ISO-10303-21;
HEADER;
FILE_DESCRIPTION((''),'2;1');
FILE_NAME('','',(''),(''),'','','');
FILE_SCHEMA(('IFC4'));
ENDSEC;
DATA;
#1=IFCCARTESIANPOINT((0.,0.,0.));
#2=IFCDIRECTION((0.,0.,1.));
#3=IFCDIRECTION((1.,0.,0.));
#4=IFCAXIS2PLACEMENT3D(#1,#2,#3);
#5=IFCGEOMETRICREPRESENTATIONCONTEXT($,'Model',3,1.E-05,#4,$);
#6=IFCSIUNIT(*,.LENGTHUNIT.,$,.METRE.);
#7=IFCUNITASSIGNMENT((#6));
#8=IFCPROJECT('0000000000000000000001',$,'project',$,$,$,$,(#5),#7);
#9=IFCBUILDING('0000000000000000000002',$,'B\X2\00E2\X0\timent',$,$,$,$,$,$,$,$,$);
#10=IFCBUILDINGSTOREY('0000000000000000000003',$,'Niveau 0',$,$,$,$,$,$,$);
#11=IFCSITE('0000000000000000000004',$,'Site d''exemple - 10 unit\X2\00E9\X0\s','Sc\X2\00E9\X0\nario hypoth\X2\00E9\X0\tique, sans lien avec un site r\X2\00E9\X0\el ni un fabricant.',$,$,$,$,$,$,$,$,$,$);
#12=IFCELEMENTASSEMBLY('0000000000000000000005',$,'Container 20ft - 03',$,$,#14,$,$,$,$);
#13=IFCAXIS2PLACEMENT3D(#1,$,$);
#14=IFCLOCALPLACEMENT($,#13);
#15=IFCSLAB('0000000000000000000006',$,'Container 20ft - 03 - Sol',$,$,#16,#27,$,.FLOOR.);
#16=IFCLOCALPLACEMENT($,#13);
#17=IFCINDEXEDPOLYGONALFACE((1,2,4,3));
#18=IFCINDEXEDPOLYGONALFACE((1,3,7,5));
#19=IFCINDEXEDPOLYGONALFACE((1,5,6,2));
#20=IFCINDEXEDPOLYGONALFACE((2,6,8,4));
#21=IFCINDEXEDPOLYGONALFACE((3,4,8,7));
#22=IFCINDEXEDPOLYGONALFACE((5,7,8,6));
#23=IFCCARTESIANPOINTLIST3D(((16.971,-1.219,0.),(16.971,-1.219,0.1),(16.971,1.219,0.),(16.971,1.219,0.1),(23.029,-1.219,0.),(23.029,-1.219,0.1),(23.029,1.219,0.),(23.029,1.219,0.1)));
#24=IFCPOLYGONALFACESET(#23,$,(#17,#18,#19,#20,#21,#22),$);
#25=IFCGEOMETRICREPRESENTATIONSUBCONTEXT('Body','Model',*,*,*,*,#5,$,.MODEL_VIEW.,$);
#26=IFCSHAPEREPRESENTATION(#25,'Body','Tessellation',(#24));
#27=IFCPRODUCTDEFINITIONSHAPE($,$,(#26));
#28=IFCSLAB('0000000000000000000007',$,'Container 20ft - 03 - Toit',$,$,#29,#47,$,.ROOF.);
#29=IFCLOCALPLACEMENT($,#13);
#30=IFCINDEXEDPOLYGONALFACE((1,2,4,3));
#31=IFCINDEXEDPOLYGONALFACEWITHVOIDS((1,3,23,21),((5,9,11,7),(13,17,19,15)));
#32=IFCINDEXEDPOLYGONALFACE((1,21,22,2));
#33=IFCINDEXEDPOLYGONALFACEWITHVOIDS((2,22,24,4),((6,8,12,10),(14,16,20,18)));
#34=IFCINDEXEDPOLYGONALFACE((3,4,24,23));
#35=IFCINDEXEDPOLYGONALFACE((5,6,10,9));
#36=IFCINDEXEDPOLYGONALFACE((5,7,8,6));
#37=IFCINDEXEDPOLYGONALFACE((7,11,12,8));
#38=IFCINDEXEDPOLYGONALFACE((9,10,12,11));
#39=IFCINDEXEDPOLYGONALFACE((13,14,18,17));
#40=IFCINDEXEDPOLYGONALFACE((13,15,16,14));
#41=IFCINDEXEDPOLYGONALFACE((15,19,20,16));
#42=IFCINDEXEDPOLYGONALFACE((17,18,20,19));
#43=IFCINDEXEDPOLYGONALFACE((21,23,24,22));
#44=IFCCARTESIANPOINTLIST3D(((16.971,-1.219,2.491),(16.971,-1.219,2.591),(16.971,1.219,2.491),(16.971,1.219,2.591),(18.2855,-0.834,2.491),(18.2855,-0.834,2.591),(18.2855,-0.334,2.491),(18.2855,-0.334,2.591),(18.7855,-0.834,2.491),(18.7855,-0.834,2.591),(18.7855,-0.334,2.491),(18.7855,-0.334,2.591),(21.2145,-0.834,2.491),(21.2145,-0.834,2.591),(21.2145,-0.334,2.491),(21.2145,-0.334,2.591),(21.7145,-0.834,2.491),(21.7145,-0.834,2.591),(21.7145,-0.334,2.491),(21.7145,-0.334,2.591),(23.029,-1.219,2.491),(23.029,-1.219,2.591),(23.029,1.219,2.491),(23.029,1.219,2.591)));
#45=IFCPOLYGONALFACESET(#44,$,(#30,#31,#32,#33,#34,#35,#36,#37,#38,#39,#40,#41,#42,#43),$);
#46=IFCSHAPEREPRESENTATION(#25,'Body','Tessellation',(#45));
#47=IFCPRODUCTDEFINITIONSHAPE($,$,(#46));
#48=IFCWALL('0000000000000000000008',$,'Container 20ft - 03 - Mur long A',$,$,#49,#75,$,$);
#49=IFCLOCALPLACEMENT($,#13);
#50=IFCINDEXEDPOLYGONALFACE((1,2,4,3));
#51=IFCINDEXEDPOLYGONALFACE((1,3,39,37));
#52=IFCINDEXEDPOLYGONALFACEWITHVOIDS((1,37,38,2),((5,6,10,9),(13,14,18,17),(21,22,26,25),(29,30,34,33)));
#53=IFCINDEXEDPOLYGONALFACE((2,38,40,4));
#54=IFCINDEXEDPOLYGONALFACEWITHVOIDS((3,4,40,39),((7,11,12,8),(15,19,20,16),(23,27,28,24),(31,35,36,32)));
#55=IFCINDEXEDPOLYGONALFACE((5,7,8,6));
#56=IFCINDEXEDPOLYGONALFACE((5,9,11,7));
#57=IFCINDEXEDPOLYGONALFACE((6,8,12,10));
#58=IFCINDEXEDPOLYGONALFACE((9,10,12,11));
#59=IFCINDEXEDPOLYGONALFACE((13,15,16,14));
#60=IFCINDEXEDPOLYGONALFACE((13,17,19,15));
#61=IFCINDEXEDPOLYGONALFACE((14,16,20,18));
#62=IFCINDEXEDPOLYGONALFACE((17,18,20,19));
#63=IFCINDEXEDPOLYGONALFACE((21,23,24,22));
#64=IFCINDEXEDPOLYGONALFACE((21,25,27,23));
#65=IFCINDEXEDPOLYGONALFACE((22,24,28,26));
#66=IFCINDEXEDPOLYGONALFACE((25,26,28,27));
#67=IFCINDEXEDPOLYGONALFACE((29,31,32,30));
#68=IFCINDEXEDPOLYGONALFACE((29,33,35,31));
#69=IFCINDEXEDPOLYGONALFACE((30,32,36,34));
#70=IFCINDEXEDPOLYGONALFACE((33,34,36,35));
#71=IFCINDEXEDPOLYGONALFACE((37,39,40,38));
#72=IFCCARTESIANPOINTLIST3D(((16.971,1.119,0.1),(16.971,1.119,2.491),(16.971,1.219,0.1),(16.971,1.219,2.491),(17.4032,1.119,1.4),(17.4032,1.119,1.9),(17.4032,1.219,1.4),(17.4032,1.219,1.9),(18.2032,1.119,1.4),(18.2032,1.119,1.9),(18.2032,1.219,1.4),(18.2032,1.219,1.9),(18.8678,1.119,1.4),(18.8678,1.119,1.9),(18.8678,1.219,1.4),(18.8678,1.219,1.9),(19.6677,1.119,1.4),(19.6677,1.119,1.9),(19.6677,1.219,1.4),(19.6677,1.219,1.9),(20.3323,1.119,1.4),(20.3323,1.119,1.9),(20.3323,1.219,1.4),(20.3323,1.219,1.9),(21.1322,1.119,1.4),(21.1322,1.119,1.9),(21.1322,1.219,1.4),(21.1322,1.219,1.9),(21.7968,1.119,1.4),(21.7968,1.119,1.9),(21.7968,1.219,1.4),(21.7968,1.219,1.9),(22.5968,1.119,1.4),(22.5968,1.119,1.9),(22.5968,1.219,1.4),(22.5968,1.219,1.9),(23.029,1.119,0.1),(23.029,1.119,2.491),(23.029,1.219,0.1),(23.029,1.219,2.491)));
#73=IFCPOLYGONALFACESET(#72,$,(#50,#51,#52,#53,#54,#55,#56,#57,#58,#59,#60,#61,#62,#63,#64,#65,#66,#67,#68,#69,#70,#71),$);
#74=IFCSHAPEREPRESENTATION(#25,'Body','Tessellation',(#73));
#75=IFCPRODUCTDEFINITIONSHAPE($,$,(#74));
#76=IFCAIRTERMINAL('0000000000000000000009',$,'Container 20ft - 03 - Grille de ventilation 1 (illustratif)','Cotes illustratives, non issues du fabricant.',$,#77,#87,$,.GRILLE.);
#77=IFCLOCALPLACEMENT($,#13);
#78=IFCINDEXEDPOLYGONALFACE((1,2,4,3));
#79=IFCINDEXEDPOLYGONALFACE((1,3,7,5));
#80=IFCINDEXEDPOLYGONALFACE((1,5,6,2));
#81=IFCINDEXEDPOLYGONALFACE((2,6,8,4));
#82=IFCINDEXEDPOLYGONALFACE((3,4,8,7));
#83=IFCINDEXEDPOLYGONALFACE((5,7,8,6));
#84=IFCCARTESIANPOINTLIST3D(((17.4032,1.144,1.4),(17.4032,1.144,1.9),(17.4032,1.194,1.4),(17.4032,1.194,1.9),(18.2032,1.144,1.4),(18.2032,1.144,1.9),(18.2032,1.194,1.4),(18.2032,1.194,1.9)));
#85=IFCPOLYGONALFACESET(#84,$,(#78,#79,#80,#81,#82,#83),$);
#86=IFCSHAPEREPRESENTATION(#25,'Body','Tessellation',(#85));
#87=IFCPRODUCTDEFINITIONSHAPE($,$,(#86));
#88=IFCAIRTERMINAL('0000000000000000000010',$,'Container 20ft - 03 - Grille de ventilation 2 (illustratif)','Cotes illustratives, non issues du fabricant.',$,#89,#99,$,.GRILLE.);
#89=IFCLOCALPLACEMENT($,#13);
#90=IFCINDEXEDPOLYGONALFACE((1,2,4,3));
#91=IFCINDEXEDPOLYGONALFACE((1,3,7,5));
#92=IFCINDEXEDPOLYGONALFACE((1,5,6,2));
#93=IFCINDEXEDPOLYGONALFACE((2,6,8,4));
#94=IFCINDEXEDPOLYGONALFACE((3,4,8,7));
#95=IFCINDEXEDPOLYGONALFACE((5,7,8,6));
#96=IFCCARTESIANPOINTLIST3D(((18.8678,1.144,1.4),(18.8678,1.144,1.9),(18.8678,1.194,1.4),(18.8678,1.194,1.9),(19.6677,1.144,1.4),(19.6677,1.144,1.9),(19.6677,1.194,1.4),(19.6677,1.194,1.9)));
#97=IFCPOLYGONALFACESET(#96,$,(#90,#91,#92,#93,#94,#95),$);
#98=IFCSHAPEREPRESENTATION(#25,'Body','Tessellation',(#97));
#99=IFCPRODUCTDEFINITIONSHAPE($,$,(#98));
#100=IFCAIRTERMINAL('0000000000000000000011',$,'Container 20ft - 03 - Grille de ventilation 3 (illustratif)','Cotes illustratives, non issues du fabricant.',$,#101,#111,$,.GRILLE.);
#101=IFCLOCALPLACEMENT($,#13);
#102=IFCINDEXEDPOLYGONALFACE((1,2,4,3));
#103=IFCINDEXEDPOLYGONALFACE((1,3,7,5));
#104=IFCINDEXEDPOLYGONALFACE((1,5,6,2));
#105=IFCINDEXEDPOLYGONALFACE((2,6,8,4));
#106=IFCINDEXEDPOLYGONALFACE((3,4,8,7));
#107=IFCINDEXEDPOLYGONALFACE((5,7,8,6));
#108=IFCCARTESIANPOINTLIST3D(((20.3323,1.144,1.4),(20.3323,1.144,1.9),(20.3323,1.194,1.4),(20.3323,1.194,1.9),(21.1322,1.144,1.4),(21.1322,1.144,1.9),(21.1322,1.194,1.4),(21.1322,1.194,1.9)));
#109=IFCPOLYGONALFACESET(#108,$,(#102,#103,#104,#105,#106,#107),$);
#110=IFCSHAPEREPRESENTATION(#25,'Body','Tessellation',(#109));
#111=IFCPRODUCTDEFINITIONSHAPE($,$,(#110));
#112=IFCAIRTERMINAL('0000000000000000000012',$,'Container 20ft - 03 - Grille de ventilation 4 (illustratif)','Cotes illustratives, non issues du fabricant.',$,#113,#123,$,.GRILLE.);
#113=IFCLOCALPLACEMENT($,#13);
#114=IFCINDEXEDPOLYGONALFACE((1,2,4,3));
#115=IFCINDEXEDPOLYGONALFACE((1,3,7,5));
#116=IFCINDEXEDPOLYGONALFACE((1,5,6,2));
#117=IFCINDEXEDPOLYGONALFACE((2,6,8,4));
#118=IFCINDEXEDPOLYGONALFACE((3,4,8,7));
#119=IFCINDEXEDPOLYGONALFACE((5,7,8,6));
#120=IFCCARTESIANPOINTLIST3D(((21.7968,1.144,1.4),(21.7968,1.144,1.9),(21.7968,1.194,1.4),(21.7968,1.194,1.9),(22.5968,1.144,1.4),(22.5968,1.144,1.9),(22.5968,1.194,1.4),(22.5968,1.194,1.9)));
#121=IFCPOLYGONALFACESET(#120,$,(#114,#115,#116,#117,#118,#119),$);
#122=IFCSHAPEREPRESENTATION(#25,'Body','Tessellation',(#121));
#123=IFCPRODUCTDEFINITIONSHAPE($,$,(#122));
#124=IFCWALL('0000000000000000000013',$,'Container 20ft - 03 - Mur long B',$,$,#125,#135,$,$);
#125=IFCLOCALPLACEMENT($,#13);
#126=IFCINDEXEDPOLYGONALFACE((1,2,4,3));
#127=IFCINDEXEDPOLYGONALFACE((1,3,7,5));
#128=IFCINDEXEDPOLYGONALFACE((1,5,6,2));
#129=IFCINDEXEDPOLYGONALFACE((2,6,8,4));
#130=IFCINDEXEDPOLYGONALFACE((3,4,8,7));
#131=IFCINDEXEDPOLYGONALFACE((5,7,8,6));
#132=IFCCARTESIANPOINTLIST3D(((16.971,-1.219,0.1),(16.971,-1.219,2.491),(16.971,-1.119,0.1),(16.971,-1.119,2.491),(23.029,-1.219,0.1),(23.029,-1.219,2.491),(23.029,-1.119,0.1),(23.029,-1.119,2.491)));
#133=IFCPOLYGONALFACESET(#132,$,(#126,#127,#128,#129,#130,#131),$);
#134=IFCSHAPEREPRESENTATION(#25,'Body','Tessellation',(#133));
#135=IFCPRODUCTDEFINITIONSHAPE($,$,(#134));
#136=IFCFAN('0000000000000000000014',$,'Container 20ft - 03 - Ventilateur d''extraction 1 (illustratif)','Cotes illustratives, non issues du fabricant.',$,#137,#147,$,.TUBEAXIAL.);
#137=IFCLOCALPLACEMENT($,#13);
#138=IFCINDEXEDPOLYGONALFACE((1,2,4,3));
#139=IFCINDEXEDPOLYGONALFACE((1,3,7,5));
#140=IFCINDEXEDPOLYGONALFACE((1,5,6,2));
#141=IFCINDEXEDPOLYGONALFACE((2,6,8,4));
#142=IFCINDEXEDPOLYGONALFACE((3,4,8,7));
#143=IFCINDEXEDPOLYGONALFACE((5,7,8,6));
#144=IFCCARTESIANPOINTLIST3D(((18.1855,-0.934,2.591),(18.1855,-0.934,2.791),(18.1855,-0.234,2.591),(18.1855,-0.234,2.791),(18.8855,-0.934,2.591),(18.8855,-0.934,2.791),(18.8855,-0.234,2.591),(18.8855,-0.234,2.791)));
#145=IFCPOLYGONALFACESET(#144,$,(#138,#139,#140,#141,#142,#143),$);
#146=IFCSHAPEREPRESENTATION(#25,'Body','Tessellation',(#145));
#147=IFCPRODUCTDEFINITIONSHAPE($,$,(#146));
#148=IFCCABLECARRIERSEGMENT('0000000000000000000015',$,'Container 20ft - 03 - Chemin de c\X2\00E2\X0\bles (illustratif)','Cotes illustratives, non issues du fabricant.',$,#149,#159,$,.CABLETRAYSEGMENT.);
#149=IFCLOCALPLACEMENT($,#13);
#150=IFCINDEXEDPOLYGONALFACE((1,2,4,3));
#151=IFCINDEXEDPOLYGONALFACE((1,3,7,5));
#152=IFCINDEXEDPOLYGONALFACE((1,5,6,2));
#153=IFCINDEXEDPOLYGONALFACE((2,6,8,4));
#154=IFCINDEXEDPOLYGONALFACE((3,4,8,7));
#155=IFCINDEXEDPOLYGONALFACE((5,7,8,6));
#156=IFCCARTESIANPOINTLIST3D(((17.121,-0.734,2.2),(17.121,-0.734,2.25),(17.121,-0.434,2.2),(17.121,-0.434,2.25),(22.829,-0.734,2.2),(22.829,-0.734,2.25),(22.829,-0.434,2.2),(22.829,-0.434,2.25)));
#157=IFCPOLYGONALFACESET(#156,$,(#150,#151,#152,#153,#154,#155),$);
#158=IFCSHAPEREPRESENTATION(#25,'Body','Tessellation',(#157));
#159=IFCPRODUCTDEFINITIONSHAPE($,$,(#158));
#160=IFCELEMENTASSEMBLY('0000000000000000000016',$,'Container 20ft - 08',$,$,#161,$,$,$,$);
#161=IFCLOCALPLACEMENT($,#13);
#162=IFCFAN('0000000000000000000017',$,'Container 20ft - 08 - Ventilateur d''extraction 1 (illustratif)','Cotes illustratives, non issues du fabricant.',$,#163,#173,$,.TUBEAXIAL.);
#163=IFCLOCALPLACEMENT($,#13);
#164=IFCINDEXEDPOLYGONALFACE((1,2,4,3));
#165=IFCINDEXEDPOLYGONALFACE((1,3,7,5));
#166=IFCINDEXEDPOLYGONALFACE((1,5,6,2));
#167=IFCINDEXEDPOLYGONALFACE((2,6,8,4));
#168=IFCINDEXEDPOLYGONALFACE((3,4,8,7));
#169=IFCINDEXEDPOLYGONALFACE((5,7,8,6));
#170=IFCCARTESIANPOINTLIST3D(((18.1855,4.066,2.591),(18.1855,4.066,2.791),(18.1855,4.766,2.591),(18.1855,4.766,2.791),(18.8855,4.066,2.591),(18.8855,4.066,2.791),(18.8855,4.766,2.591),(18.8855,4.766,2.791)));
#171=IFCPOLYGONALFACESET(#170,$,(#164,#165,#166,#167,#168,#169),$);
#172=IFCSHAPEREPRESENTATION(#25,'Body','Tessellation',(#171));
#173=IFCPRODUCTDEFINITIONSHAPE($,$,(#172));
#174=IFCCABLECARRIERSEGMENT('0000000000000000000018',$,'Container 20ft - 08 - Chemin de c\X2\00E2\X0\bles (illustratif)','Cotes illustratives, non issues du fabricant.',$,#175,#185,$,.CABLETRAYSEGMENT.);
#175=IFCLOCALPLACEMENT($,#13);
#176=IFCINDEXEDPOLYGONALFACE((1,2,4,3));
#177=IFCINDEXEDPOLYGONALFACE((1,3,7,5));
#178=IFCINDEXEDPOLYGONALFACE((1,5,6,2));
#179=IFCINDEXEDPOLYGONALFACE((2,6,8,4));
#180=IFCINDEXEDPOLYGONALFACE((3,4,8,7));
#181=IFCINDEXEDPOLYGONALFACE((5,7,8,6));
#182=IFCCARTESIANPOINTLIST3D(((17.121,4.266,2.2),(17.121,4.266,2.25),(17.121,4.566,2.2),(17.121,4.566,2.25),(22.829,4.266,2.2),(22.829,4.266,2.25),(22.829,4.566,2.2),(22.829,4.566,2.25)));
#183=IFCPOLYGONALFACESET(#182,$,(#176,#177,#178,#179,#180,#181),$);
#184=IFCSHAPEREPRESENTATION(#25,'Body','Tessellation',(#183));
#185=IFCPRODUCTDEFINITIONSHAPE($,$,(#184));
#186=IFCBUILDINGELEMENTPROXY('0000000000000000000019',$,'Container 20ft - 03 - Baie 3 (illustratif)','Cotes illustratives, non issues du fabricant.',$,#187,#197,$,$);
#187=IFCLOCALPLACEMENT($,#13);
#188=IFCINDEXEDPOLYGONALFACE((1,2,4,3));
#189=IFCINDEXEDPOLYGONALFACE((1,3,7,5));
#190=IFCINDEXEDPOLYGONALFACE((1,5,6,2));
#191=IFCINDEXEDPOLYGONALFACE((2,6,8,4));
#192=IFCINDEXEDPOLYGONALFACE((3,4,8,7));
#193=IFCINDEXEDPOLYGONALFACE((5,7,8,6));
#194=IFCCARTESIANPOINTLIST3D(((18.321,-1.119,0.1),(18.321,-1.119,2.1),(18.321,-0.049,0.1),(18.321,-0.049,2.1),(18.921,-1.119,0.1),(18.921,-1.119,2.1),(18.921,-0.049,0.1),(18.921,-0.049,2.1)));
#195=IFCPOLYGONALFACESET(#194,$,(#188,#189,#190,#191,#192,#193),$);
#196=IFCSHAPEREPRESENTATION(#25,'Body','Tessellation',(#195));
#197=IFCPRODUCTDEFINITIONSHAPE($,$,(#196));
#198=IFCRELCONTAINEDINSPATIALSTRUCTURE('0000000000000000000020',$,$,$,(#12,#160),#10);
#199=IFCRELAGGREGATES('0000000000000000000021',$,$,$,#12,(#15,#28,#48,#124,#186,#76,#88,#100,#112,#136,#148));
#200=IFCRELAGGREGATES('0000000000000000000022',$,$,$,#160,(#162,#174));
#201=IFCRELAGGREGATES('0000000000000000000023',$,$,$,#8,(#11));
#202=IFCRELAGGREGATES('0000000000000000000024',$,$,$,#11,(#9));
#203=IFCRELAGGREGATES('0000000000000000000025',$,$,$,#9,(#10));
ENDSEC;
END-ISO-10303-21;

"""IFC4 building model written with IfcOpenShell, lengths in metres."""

from ifc_helpers import new_model, si_unit, frame, origin_with_axes, place, context, subcontext, project, spatial, rectangle, extrude, element, fill, aggregate, save


model = new_model("IFC4")

# Units and contexts
model_context = context("Model", 3, precision=1e-05, world=origin_with_axes())
body_context = subcontext(model_context, "Body", "Model", "MODEL_VIEW")
ifc_project = project(units=[si_unit("LENGTHUNIT", "METRE")], contexts=[model_context])

# Site, building, storey
site = spatial("IfcSite", under=ifc_project, Name="Site d'exemple - 10 unités", Description="Scénario hypothétique, sans lien avec un site réel ni un fabricant.")
building = spatial("IfcBuilding", under=site, Name="Bâtiment")
storey = spatial("IfcBuildingStorey", under=building, Name="Niveau 0")

# Element assembly, slabs, openings, walls, air terminals, fan, cable carrier segment
assembly_1 = element("IfcElementAssembly", 1, inside=storey, Name="Container 20ft - 03")
slab_1_placement = place(None, frame((20.0, 0.0, 0.0), z_axis=(0.0, 0.0, 1.0), x_axis=(1.0, 0.0, 0.0)))
slab_1 = element("IfcSlab", 2, at=slab_1_placement, Name="Container 20ft - 03 - Sol", PredefinedType="FLOOR", context=body_context, shape_type="SweptSolid", body=[
    extrude(rectangle(XDim=6.058, YDim=2.438), origin_with_axes(), (0.0, 0.0, 1.0), 0.1),
])
slab_2_placement = place(None, frame((20.0, 0.0, 2.491), z_axis=(0.0, 0.0, 1.0), x_axis=(1.0, 0.0, 0.0)))
slab_2 = element("IfcSlab", 3, at=slab_2_placement, Name="Container 20ft - 03 - Toit", PredefinedType="ROOF", context=body_context, shape_type="SweptSolid", body=[
    extrude(rectangle(XDim=6.058, YDim=2.438), origin_with_axes(), (0.0, 0.0, 1.0), 0.1),
])
opening_1_placement = place(None, frame((18.5355, -0.584, 2.441), z_axis=(0.0, 0.0, 1.0), x_axis=(1.0, 0.0, 0.0)))
element("IfcOpeningElement", 4, at=opening_1_placement, cuts=slab_2, PredefinedType="OPENING", context=body_context, shape_type="SweptSolid", body=[
    extrude(rectangle(XDim=0.5, YDim=0.5), origin_with_axes(), (0.0, 0.0, 1.0), 0.2),
])
opening_2_placement = place(None, frame((21.4645, -0.584, 2.441), z_axis=(0.0, 0.0, 1.0), x_axis=(1.0, 0.0, 0.0)))
element("IfcOpeningElement", 5, at=opening_2_placement, cuts=slab_2, PredefinedType="OPENING", context=body_context, shape_type="SweptSolid", body=[
    extrude(rectangle(XDim=0.5, YDim=0.5), origin_with_axes(), (0.0, 0.0, 1.0), 0.2),
])
wall_1_placement = place(None, frame((20.0, 1.169, 0.1), z_axis=(0.0, 0.0, 1.0), x_axis=(1.0, 0.0, 0.0)))
wall_1 = element("IfcWall", 6, at=wall_1_placement, Name="Container 20ft - 03 - Mur long A", context=body_context, shape_type="SweptSolid", body=[
    extrude(rectangle(XDim=6.058, YDim=0.1), origin_with_axes(), (0.0, 0.0, 1.0), 2.391),
])
opening_3_placement = place(None, frame((17.8032, 1.169, 1.4), z_axis=(0.0, 0.0, 1.0), x_axis=(1.0, 0.0, 0.0)))
opening_3 = element("IfcOpeningElement", 7, at=opening_3_placement, cuts=wall_1, PredefinedType="OPENING", context=body_context, shape_type="SweptSolid", body=[
    extrude(rectangle(XDim=0.8, YDim=0.2), origin_with_axes(), (0.0, 0.0, 1.0), 0.5),
])
opening_4_placement = place(None, frame((19.2677, 1.169, 1.4), z_axis=(0.0, 0.0, 1.0), x_axis=(1.0, 0.0, 0.0)))
opening_4 = element("IfcOpeningElement", 8, at=opening_4_placement, cuts=wall_1, PredefinedType="OPENING", context=body_context, shape_type="SweptSolid", body=[
    extrude(rectangle(XDim=0.8, YDim=0.2), origin_with_axes(), (0.0, 0.0, 1.0), 0.5),
])
opening_5_placement = place(None, frame((20.7323, 1.169, 1.4), z_axis=(0.0, 0.0, 1.0), x_axis=(1.0, 0.0, 0.0)))
opening_5 = element("IfcOpeningElement", 9, at=opening_5_placement, cuts=wall_1, PredefinedType="OPENING", context=body_context, shape_type="SweptSolid", body=[
    extrude(rectangle(XDim=0.8, YDim=0.2), origin_with_axes(), (0.0, 0.0, 1.0), 0.5),
])
opening_6_placement = place(None, frame((22.1968, 1.169, 1.4), z_axis=(0.0, 0.0, 1.0), x_axis=(1.0, 0.0, 0.0)))
opening_6 = element("IfcOpeningElement", 10, at=opening_6_placement, cuts=wall_1, PredefinedType="OPENING", context=body_context, shape_type="SweptSolid", body=[
    extrude(rectangle(XDim=0.8, YDim=0.2), origin_with_axes(), (0.0, 0.0, 1.0), 0.5),
])
air_terminal_1_placement = place(None, frame((17.8032, 1.169, 1.4), z_axis=(0.0, 0.0, 1.0), x_axis=(1.0, 0.0, 0.0)))
air_terminal_1 = element("IfcAirTerminal", 11, at=air_terminal_1_placement, Name="Container 20ft - 03 - Grille de ventilation 1 (illustratif)", Description="Cotes illustratives, non issues du fabricant.", PredefinedType="GRILLE", context=body_context, shape_type="SweptSolid", body=[
    extrude(rectangle(XDim=0.8, YDim=0.05), origin_with_axes(), (0.0, 0.0, 1.0), 0.5),
])
fill(opening_3, air_terminal_1)
air_terminal_2_placement = place(None, frame((19.2677, 1.169, 1.4), z_axis=(0.0, 0.0, 1.0), x_axis=(1.0, 0.0, 0.0)))
air_terminal_2 = element("IfcAirTerminal", 12, at=air_terminal_2_placement, Name="Container 20ft - 03 - Grille de ventilation 2 (illustratif)", Description="Cotes illustratives, non issues du fabricant.", PredefinedType="GRILLE", context=body_context, shape_type="SweptSolid", body=[
    extrude(rectangle(XDim=0.8, YDim=0.05), origin_with_axes(), (0.0, 0.0, 1.0), 0.5),
])
fill(opening_4, air_terminal_2)
air_terminal_3_placement = place(None, frame((20.7323, 1.169, 1.4), z_axis=(0.0, 0.0, 1.0), x_axis=(1.0, 0.0, 0.0)))
air_terminal_3 = element("IfcAirTerminal", 13, at=air_terminal_3_placement, Name="Container 20ft - 03 - Grille de ventilation 3 (illustratif)", Description="Cotes illustratives, non issues du fabricant.", PredefinedType="GRILLE", context=body_context, shape_type="SweptSolid", body=[
    extrude(rectangle(XDim=0.8, YDim=0.05), origin_with_axes(), (0.0, 0.0, 1.0), 0.5),
])
fill(opening_5, air_terminal_3)
air_terminal_4_placement = place(None, frame((22.1968, 1.169, 1.4), z_axis=(0.0, 0.0, 1.0), x_axis=(1.0, 0.0, 0.0)))
air_terminal_4 = element("IfcAirTerminal", 14, at=air_terminal_4_placement, Name="Container 20ft - 03 - Grille de ventilation 4 (illustratif)", Description="Cotes illustratives, non issues du fabricant.", PredefinedType="GRILLE", context=body_context, shape_type="SweptSolid", body=[
    extrude(rectangle(XDim=0.8, YDim=0.05), origin_with_axes(), (0.0, 0.0, 1.0), 0.5),
])
fill(opening_6, air_terminal_4)
wall_2_placement = place(None, frame((20.0, -1.169, 0.1), z_axis=(0.0, 0.0, 1.0), x_axis=(1.0, 0.0, 0.0)))
wall_2 = element("IfcWall", 15, at=wall_2_placement, Name="Container 20ft - 03 - Mur long B", context=body_context, shape_type="SweptSolid", body=[
    extrude(rectangle(XDim=6.058, YDim=0.1), origin_with_axes(), (0.0, 0.0, 1.0), 2.391),
])
fan_1_placement = place(None, frame((18.5355, -0.584, 2.591), z_axis=(0.0, 0.0, 1.0), x_axis=(1.0, 0.0, 0.0)))
fan_1 = element("IfcFan", 16, at=fan_1_placement, Name="Container 20ft - 03 - Ventilateur d'extraction 1 (illustratif)", Description="Cotes illustratives, non issues du fabricant.", PredefinedType="TUBEAXIAL", context=body_context, shape_type="SweptSolid", body=[
    extrude(rectangle(XDim=0.7, YDim=0.7), origin_with_axes(), (0.0, 0.0, 1.0), 0.2),
])
cable_carrier_segment_1_placement = place(None, frame((19.975, -0.584, 2.2), z_axis=(0.0, 0.0, 1.0), x_axis=(1.0, 0.0, 0.0)))
cable_carrier_segment_1 = element("IfcCableCarrierSegment", 17, at=cable_carrier_segment_1_placement, Name="Container 20ft - 03 - Chemin de câbles (illustratif)", Description="Cotes illustratives, non issues du fabricant.", PredefinedType="CABLETRAYSEGMENT", context=body_context, shape_type="SweptSolid", body=[
    extrude(rectangle(XDim=5.708, YDim=0.3), origin_with_axes(), (0.0, 0.0, 1.0), 0.05),
])

# Element assembly, fan, cable carrier segment
assembly_2 = element("IfcElementAssembly", 18, inside=storey, Name="Container 20ft - 08")
fan_2_placement = place(None, frame((18.5355, 4.416, 2.591), z_axis=(0.0, 0.0, 1.0), x_axis=(1.0, 0.0, 0.0)))
fan_2 = element("IfcFan", 19, at=fan_2_placement, Name="Container 20ft - 08 - Ventilateur d'extraction 1 (illustratif)", Description="Cotes illustratives, non issues du fabricant.", PredefinedType="TUBEAXIAL", context=body_context, shape_type="SweptSolid", body=[
    extrude(rectangle(XDim=0.7, YDim=0.7), origin_with_axes(), (0.0, 0.0, 1.0), 0.2),
])
cable_carrier_segment_2_placement = place(None, frame((19.975, 4.416, 2.2), z_axis=(0.0, 0.0, 1.0), x_axis=(1.0, 0.0, 0.0)))
cable_carrier_segment_2 = element("IfcCableCarrierSegment", 20, at=cable_carrier_segment_2_placement, Name="Container 20ft - 08 - Chemin de câbles (illustratif)", Description="Cotes illustratives, non issues du fabricant.", PredefinedType="CABLETRAYSEGMENT", context=body_context, shape_type="SweptSolid", body=[
    extrude(rectangle(XDim=5.708, YDim=0.3), origin_with_axes(), (0.0, 0.0, 1.0), 0.05),
])

# Building element proxy
proxy_1_placement = place(None, frame((18.621, -0.584, 0.1), z_axis=(0.0, 0.0, 1.0), x_axis=(1.0, 0.0, 0.0)))
proxy_1 = element("IfcBuildingElementProxy", 21, at=proxy_1_placement, Name="Container 20ft - 03 - Baie 3 (illustratif)", Description="Cotes illustratives, non issues du fabricant.", context=body_context, shape_type="SweptSolid", body=[
    extrude(rectangle(XDim=0.6, YDim=1.07), origin_with_axes(), (0.0, 0.0, 1.0), 2.0),
])
aggregate(assembly_1, [slab_1, slab_2, wall_1, wall_2, proxy_1, air_terminal_1, air_terminal_2, air_terminal_3, air_terminal_4, fan_1, cable_carrier_segment_1])
aggregate(assembly_2, [fan_2, cable_carrier_segment_2])

save(model, "model.ifc")
